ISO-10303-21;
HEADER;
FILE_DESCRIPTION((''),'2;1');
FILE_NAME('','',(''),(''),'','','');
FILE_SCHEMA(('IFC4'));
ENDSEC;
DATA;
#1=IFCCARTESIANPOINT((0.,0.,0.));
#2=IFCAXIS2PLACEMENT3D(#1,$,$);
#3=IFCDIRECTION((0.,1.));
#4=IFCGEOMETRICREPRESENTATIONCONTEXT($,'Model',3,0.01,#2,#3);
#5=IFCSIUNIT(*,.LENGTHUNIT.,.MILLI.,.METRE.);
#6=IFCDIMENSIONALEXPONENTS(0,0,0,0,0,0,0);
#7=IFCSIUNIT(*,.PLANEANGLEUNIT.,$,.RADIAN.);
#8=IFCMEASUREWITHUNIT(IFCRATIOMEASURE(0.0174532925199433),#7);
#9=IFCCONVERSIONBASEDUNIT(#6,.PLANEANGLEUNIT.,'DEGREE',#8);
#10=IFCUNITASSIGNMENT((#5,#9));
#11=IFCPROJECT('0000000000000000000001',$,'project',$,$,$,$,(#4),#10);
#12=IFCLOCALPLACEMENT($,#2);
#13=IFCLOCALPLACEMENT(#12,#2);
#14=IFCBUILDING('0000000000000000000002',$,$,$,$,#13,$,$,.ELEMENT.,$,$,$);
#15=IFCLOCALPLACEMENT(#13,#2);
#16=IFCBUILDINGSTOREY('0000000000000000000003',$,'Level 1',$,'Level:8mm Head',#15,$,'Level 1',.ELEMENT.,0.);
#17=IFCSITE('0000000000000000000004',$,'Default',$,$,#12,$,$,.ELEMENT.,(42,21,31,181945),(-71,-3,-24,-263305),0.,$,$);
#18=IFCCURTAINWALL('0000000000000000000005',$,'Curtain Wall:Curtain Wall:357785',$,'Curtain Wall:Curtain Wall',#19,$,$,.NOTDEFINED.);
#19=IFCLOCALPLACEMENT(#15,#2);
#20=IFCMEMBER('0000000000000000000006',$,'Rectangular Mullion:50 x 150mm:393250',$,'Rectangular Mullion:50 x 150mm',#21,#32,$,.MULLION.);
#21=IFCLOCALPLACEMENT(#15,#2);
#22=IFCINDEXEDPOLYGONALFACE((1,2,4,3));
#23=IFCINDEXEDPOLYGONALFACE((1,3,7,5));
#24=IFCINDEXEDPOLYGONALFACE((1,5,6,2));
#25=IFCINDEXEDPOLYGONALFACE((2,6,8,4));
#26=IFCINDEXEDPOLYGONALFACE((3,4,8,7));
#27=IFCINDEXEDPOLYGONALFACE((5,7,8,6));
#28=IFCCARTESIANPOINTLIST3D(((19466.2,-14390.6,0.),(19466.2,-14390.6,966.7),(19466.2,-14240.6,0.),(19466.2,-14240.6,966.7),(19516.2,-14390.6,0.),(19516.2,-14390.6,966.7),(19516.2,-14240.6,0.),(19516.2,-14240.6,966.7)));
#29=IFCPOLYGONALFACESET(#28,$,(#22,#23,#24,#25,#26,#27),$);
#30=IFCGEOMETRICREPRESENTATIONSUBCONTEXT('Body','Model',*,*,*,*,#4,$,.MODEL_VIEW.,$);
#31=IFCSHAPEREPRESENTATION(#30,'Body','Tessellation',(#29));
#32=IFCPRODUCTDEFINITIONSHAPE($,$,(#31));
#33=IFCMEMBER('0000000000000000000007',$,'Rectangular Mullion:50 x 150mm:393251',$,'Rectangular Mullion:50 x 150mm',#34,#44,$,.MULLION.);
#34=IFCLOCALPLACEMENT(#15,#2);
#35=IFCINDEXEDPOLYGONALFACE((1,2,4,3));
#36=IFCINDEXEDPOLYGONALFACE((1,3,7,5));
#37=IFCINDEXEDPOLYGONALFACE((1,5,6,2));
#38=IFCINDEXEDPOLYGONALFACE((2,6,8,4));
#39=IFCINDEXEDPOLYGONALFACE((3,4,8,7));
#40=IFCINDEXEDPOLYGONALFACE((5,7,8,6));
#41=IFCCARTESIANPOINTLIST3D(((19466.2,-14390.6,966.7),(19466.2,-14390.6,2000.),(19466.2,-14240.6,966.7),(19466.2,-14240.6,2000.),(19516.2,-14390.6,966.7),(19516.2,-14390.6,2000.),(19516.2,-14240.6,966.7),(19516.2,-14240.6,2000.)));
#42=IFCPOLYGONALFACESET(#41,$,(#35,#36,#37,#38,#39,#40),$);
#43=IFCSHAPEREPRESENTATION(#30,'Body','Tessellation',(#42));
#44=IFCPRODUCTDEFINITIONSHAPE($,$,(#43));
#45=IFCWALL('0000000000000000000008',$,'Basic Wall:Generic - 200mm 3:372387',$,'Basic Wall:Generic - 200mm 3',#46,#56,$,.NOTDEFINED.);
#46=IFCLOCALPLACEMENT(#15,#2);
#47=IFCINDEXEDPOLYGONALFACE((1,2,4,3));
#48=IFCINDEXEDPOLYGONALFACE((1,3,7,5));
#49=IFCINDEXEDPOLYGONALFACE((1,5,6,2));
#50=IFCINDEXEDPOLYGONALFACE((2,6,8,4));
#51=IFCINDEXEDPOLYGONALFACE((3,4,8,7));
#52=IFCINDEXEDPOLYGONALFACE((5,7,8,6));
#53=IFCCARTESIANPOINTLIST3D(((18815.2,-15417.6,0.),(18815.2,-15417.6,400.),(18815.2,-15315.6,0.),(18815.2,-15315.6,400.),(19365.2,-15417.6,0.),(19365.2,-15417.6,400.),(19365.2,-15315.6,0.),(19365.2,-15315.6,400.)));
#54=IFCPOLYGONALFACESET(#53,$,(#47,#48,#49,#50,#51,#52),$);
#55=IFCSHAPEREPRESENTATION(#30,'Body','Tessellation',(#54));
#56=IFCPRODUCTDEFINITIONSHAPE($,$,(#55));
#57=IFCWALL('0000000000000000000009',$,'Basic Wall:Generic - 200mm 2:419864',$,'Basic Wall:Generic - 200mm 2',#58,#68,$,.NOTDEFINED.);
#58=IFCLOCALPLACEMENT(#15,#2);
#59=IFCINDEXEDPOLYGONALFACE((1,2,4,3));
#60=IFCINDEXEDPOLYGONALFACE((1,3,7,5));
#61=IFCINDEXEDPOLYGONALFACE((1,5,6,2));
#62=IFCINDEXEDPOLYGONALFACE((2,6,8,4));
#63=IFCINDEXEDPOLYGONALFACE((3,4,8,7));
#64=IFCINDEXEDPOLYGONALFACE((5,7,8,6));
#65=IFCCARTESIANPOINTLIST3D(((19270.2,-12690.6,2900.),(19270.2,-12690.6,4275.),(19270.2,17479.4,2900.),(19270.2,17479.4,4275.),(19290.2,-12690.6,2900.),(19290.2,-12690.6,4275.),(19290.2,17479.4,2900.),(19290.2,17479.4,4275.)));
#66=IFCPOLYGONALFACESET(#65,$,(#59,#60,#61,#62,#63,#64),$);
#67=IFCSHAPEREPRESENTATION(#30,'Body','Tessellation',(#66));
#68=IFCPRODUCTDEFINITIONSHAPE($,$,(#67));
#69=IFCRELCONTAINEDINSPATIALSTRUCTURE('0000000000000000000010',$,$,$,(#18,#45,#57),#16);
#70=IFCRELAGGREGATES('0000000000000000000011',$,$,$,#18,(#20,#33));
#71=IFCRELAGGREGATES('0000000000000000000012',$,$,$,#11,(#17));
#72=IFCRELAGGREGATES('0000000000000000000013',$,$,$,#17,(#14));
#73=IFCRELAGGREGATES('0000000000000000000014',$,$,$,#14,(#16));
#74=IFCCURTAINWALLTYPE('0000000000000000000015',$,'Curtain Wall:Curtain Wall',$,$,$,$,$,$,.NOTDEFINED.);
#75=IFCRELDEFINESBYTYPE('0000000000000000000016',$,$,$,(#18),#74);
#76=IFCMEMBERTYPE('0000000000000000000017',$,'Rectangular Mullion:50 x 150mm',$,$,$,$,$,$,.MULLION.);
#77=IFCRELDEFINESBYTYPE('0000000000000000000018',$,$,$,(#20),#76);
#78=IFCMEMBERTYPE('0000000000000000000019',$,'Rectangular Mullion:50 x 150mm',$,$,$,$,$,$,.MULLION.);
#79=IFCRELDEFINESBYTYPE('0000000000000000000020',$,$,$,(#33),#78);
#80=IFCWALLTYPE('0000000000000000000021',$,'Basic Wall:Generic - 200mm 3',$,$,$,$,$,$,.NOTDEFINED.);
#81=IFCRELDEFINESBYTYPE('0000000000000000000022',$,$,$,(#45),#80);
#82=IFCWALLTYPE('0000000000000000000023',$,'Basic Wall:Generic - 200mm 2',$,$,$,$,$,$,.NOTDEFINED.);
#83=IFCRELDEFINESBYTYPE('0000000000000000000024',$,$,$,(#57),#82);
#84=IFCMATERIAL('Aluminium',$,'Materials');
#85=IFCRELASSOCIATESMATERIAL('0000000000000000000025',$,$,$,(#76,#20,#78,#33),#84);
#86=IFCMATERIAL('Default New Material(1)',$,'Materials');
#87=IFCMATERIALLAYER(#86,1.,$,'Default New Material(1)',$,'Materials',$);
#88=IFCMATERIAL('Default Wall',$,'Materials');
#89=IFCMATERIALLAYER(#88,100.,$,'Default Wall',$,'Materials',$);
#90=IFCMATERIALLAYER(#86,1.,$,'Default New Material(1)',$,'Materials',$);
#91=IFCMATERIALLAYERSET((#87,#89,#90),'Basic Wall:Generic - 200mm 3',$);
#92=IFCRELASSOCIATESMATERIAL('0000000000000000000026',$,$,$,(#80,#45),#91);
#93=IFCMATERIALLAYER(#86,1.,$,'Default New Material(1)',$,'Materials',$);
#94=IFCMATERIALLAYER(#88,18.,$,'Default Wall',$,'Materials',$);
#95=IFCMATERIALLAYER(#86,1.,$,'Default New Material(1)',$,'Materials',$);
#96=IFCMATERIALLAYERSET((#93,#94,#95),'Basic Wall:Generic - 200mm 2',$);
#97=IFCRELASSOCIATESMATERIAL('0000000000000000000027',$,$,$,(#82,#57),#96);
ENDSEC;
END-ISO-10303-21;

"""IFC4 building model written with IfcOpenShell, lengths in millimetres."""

from ifc_helpers import new_model, entity, si_unit, converted_unit, direction, frame, origin, place, context, subcontext, project, spatial, indexed_curve, outline, extrude, source, transform, mapped, material, layer, layer_set, type_object, type_shapes, element, aggregate, save


model = new_model("IFC4")

# Units and contexts
model_context = context("Model", 3, precision=0.01, world=origin(), true_north=direction((0.0, 1.0)))
body_context = subcontext(model_context, "Body", "Model", "MODEL_VIEW")
ifc_project = project(units=[si_unit("LENGTHUNIT", "METRE", prefix="MILLI"), converted_unit("PLANEANGLEUNIT", "DEGREE", entity("IfcRatioMeasure", 0.0174532925199433), si_unit("PLANEANGLEUNIT", "RADIAN"), dimensions=[0, 0, 0, 0, 0, 0, 0])], contexts=[model_context])

# Site, building, storey
site_placement = place(None, origin())
site = spatial("IfcSite", under=ifc_project, at=site_placement, Name="Default", CompositionType="ELEMENT", RefLatitude=(42, 21, 31, 181945), RefLongitude=(-71, -3, -24, -263305), RefElevation=0.0)
building_placement = place(site_placement, origin())
building = spatial("IfcBuilding", under=site, at=building_placement, CompositionType="ELEMENT")
storey_placement = place(building_placement, origin())
storey = spatial("IfcBuildingStorey", under=building, at=storey_placement, Name="Level 1", ObjectType="Level:8mm Head", LongName="Level 1", CompositionType="ELEMENT", Elevation=0.0)

# Shared definitions
ifc_material_1 = material(Name="Aluminium", Category="Materials")

# Curtain wall, members
curtain_wall_type_1 = type_object("IfcCurtainWallType", Name="Curtain Wall:Curtain Wall", PredefinedType="NOTDEFINED")
curtain_wall_1_placement = place(storey_placement, origin())
curtain_wall_1 = element("IfcCurtainWall", 1, at=curtain_wall_1_placement, inside=storey, type_object=curtain_wall_type_1, Name="Curtain Wall:Curtain Wall:357785", ObjectType="Curtain Wall:Curtain Wall", PredefinedType="NOTDEFINED")
member_type_1 = type_object("IfcMemberType", Name="Rectangular Mullion:50 x 150mm", PredefinedType="MULLION", material=ifc_material_1)
shared_shape_1 = source(origin(), body_context, "Body", "SweptSolid", [
    extrude(outline(indexed_curve([(-75.0, -25.0), (75.0, -25.0), (75.0, 25.0), (-75.0, 25.0), (-75.0, -25.0)], self_intersect=False)), frame((-25.0, 0.0, -966.7), z_axis=(0.0, 0.0, 1.0), x_axis=(0.0, -1.0, 0.0)), (0.0, 0.0, 1.0), 966.7),
])
type_shapes(member_type_1, [shared_shape_1])
member_1_placement = place(storey_placement, frame((19466.2, -14315.6, 966.7), z_axis=(0.0, 0.0, 1.0), x_axis=(-1.0, 0.0, 0.0)))
member_1 = element("IfcMember", 2, at=member_1_placement, type_object=member_type_1, material=ifc_material_1, Name="Rectangular Mullion:50 x 150mm:393250", ObjectType="Rectangular Mullion:50 x 150mm", PredefinedType="MULLION", context=body_context, shape_type="MappedRepresentation", body=[
    mapped(shared_shape_1, transform((0.0, 0.0, 0.0), scale=1.0)),
])
member_type_2 = type_object("IfcMemberType", Name="Rectangular Mullion:50 x 150mm", PredefinedType="MULLION", material=ifc_material_1)
shared_shape_2 = source(origin(), body_context, "Body", "SweptSolid", [
    extrude(outline(indexed_curve([(-75.0, -25.0), (75.0, -25.0), (75.0, 25.0), (-75.0, 25.0), (-75.0, -25.0)], self_intersect=False)), frame((-25.0, 0.0, -1033.3), z_axis=(0.0, 0.0, 1.0), x_axis=(0.0, -1.0, 0.0)), (0.0, 0.0, 1.0), 1033.3),
])
type_shapes(member_type_2, [shared_shape_2])
member_2_placement = place(storey_placement, frame((19466.2, -14315.6, 2000.0), z_axis=(0.0, 0.0, 1.0), x_axis=(-1.0, 0.0, 0.0)))
member_2 = element("IfcMember", 3, at=member_2_placement, type_object=member_type_2, material=ifc_material_1, Name="Rectangular Mullion:50 x 150mm:393251", ObjectType="Rectangular Mullion:50 x 150mm", PredefinedType="MULLION", context=body_context, shape_type="MappedRepresentation", body=[
    mapped(shared_shape_2, transform((0.0, 0.0, 0.0), scale=1.0)),
])
aggregate(curtain_wall_1, [member_1, member_2])

# Walls
ifc_material_2 = material(Name="Default New Material(1)", Category="Materials")
ifc_layer_1 = layer(ifc_material_2, 1.0, Name="Default New Material(1)", Category="Materials")
ifc_material_3 = material(Name="Default Wall", Category="Materials")
ifc_layer_2 = layer(ifc_material_3, 100.0, Name="Default Wall", Category="Materials")
ifc_layer_3 = layer(ifc_material_2, 1.0, Name="Default New Material(1)", Category="Materials")
ifc_layer_set_1 = layer_set([ifc_layer_1, ifc_layer_2, ifc_layer_3], Name="Basic Wall:Generic - 200mm 3")
wall_type_1 = type_object("IfcWallType", Name="Basic Wall:Generic - 200mm 3", PredefinedType="NOTDEFINED", material=ifc_layer_set_1)
wall_1_placement = place(storey_placement, frame((19365.2, -15366.6, 0.0), z_axis=(0.0, 0.0, 1.0), x_axis=(-1.0, 0.0, 0.0)))
element("IfcWall", 4, at=wall_1_placement, inside=storey, type_object=wall_type_1, material=ifc_layer_set_1, Name="Basic Wall:Generic - 200mm 3:372387", ObjectType="Basic Wall:Generic - 200mm 3", PredefinedType="NOTDEFINED", context=body_context, shape_type="SweptSolid", body=[
    extrude(outline(indexed_curve([(550.0, 51.0), (0.0, 51.0), (0.0, -51.0), (550.0, -51.0), (550.0, 51.0)], self_intersect=False)), origin(), (0.0, 0.0, 1.0), 400.0),
])
ifc_layer_4 = layer(ifc_material_2, 1.0, Name="Default New Material(1)", Category="Materials")
ifc_layer_5 = layer(ifc_material_3, 18.0, Name="Default Wall", Category="Materials")
ifc_layer_6 = layer(ifc_material_2, 1.0, Name="Default New Material(1)", Category="Materials")
ifc_layer_set_2 = layer_set([ifc_layer_4, ifc_layer_5, ifc_layer_6], Name="Basic Wall:Generic - 200mm 2")
wall_type_2 = type_object("IfcWallType", Name="Basic Wall:Generic - 200mm 2", PredefinedType="NOTDEFINED", material=ifc_layer_set_2)
wall_2_placement = place(storey_placement, frame((19280.2, -12690.6, 2900.0), z_axis=(0.0, 0.0, 1.0), x_axis=(0.0, 1.0, 0.0)))
element("IfcWall", 5, at=wall_2_placement, inside=storey, type_object=wall_type_2, material=ifc_layer_set_2, Name="Basic Wall:Generic - 200mm 2:419864", ObjectType="Basic Wall:Generic - 200mm 2", PredefinedType="NOTDEFINED", context=body_context, shape_type="SweptSolid", body=[
    extrude(outline(indexed_curve([(30170.0, 10.0), (0.0, 10.0), (0.0, -10.0), (30170.0, -10.0), (30170.0, 10.0)], self_intersect=False)), origin(), (0.0, 0.0, 1.0), 1375.0),
])

save(model, "model.ifc")
